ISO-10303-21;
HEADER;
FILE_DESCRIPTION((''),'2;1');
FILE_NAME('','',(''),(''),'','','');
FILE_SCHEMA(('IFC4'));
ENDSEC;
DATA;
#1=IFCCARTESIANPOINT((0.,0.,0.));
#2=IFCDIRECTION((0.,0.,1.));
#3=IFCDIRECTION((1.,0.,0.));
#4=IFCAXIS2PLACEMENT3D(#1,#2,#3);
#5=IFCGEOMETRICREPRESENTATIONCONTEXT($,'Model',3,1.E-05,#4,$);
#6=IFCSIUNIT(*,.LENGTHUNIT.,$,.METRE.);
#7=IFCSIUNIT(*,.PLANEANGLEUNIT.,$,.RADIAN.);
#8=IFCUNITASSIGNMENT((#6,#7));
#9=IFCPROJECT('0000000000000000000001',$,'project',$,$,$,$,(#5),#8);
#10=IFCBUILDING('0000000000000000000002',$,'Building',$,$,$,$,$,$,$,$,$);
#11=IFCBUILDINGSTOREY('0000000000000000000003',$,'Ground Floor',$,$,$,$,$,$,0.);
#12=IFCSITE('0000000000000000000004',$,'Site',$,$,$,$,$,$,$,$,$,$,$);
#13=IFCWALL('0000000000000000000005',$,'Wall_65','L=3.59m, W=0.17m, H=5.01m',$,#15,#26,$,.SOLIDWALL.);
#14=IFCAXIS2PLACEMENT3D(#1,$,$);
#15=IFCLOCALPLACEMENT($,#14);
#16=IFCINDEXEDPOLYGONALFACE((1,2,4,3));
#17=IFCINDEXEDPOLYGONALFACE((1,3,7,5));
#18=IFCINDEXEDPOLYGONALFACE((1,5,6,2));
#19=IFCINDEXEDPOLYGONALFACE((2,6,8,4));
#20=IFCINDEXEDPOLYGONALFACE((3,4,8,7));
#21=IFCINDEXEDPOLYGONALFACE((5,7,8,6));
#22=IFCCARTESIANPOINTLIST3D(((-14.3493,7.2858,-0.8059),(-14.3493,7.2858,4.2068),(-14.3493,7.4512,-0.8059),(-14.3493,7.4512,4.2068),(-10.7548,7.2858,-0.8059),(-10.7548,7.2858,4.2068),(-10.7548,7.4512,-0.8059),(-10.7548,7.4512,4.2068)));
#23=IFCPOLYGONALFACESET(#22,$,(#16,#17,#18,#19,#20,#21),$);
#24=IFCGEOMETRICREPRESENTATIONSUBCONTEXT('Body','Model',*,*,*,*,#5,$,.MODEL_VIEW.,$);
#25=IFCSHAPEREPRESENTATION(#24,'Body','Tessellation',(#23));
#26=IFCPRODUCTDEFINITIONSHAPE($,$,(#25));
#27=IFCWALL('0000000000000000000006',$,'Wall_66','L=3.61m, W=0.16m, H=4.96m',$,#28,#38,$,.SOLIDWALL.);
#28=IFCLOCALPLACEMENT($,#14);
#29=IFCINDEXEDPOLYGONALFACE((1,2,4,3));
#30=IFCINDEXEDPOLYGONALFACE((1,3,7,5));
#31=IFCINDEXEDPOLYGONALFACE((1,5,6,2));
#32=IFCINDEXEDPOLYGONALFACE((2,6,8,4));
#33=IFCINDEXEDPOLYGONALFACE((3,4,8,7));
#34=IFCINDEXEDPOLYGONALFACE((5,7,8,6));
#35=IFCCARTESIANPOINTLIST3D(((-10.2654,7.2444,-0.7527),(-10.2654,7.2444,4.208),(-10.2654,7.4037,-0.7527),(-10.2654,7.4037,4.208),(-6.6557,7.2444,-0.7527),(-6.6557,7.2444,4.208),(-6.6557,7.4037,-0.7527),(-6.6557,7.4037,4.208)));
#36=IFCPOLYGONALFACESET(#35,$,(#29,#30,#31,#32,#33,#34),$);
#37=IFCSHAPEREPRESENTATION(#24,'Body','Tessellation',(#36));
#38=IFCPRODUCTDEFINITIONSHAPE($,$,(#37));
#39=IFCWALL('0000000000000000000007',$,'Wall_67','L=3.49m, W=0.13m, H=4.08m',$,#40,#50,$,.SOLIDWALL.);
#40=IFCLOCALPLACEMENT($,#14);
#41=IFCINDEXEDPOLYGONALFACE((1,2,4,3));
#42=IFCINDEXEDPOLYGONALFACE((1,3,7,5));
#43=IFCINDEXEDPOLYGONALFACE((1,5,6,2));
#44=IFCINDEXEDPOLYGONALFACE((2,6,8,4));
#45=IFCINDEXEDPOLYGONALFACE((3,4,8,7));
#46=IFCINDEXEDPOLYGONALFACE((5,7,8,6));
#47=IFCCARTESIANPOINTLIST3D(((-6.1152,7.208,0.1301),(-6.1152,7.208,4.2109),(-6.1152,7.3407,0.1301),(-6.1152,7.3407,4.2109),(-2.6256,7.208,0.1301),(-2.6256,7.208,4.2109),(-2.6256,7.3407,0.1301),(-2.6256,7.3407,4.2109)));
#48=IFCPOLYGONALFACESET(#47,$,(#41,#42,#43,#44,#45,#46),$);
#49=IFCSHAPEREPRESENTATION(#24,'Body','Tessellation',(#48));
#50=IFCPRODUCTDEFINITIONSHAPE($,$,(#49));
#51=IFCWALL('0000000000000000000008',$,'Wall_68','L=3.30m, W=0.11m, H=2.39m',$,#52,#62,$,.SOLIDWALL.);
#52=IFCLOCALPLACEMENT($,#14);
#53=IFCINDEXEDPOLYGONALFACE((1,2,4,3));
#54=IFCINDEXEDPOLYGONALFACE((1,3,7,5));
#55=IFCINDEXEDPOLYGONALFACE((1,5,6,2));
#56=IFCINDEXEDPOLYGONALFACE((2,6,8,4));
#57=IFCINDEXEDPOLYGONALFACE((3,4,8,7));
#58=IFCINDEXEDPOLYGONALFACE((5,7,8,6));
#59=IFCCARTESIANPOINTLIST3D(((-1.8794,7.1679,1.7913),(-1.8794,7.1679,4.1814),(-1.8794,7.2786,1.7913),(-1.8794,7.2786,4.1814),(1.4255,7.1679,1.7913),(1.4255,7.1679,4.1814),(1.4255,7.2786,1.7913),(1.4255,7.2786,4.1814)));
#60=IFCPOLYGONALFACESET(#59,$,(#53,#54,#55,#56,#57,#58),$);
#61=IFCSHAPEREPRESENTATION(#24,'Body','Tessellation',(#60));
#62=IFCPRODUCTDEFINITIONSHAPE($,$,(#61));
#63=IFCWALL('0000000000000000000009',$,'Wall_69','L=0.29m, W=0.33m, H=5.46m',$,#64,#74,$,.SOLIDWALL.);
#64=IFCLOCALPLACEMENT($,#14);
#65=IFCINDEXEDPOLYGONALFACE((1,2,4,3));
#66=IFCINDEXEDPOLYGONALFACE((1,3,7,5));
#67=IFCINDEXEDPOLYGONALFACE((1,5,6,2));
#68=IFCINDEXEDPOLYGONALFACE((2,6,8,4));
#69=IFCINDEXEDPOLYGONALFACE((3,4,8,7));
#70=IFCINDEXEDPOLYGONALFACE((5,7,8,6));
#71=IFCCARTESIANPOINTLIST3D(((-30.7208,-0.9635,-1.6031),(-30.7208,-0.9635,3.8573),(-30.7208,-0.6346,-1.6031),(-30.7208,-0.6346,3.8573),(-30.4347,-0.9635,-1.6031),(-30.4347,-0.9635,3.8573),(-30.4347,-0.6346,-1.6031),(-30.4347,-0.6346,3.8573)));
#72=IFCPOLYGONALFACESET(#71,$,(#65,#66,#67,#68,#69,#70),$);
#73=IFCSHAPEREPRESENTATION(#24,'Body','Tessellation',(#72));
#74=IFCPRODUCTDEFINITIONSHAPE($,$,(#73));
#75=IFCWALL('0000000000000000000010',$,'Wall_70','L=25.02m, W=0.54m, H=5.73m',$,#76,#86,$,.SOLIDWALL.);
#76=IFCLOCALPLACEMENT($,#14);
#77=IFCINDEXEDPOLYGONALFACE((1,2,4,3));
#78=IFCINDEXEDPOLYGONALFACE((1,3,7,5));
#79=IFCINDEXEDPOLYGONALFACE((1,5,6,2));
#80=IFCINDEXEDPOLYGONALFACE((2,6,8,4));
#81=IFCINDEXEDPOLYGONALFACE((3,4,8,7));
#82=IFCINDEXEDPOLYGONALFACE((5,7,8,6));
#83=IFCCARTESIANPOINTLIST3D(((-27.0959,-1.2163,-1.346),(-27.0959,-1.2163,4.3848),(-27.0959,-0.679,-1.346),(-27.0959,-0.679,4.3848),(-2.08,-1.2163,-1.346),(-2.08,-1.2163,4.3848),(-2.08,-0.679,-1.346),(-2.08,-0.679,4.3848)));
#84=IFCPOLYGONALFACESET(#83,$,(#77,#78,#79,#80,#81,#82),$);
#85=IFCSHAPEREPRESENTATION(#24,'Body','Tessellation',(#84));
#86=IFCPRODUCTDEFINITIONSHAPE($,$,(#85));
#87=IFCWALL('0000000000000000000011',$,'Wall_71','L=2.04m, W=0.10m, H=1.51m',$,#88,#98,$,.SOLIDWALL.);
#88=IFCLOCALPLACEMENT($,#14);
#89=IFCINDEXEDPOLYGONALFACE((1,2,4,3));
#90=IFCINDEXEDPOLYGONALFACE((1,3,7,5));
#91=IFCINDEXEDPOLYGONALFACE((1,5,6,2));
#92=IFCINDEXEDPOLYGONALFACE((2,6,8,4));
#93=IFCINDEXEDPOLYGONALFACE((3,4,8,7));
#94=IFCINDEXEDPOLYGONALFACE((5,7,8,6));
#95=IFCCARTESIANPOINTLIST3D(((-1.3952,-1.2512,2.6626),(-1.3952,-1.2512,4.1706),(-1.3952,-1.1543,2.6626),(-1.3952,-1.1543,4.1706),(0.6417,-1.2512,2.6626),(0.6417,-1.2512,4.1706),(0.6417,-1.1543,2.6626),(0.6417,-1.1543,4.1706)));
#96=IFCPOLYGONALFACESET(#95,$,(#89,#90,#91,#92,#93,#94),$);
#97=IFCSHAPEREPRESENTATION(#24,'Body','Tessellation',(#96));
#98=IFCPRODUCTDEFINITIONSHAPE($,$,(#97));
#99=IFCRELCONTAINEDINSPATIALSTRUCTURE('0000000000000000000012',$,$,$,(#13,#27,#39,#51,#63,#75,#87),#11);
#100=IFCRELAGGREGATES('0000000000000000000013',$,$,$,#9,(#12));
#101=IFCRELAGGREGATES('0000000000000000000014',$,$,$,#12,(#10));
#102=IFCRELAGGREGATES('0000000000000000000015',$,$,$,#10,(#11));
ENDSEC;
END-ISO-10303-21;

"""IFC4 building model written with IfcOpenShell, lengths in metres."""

from ifc_helpers import new_model, si_unit, frame, origin_with_axes, origin_2d, context, subcontext, project, spatial, rectangle, extrude, element, save


model = new_model("IFC4")

# Units and contexts
model_context = context("Model", 3, precision=1e-05, world=origin_with_axes())
body_context = subcontext(model_context, "Body", "Model", "MODEL_VIEW")
ifc_project = project(units=[si_unit("LENGTHUNIT", "METRE"), si_unit("PLANEANGLEUNIT", "RADIAN")], contexts=[model_context])

# Site, building, storey
site = spatial("IfcSite", under=ifc_project, Name="Site")
building = spatial("IfcBuilding", under=site, Name="Building")
storey = spatial("IfcBuildingStorey", under=building, Name="Ground Floor", Elevation=0.0)

# Walls
element("IfcWall", 1, inside=storey, Name="Wall_65", Description="L=3.59m, W=0.17m, H=5.01m", PredefinedType="SOLIDWALL", context=body_context, shape_type="SweptSolid", body=[
    extrude(rectangle(XDim=3.5945, YDim=0.1655, at=origin_2d()), frame((-12.552, 7.3685, -0.8059), z_axis=(0.0, 0.0, 1.0), x_axis=(1.0, 0.0, 0.0)), (0.0, 0.0, 1.0), 5.0127),
])
element("IfcWall", 2, inside=storey, Name="Wall_66", Description="L=3.61m, W=0.16m, H=4.96m", PredefinedType="SOLIDWALL", context=body_context, shape_type="SweptSolid", body=[
    extrude(rectangle(XDim=3.6097, YDim=0.1593, at=origin_2d()), frame((-8.4605, 7.324, -0.7527), z_axis=(0.0, 0.0, 1.0), x_axis=(1.0, 0.0, 0.0)), (0.0, 0.0, 1.0), 4.9606),
])
element("IfcWall", 3, inside=storey, Name="Wall_67", Description="L=3.49m, W=0.13m, H=4.08m", PredefinedType="SOLIDWALL", context=body_context, shape_type="SweptSolid", body=[
    extrude(rectangle(XDim=3.4897, YDim=0.1327, at=origin_2d()), frame((-4.3704, 7.2743, 0.1301), z_axis=(0.0, 0.0, 1.0), x_axis=(1.0, 0.0, 0.0)), (0.0, 0.0, 1.0), 4.0809),
])
element("IfcWall", 4, inside=storey, Name="Wall_68", Description="L=3.30m, W=0.11m, H=2.39m", PredefinedType="SOLIDWALL", context=body_context, shape_type="SweptSolid", body=[
    extrude(rectangle(XDim=3.305, YDim=0.1107, at=origin_2d()), frame((-0.227, 7.2232, 1.7913), z_axis=(0.0, 0.0, 1.0), x_axis=(1.0, 0.0, 0.0)), (0.0, 0.0, 1.0), 2.3901),
])
element("IfcWall", 5, inside=storey, Name="Wall_69", Description="L=0.29m, W=0.33m, H=5.46m", PredefinedType="SOLIDWALL", context=body_context, shape_type="SweptSolid", body=[
    extrude(rectangle(XDim=0.2861, YDim=0.3289, at=origin_2d()), frame((-30.5778, -0.799, -1.6031), z_axis=(0.0, 0.0, 1.0), x_axis=(1.0, 0.0, 0.0)), (0.0, 0.0, 1.0), 5.4605),
])
element("IfcWall", 6, inside=storey, Name="Wall_70", Description="L=25.02m, W=0.54m, H=5.73m", PredefinedType="SOLIDWALL", context=body_context, shape_type="SweptSolid", body=[
    extrude(rectangle(XDim=25.0159, YDim=0.5374, at=origin_2d()), frame((-14.5879, -0.9476, -1.346), z_axis=(0.0, 0.0, 1.0), x_axis=(1.0, 0.0, 0.0)), (0.0, 0.0, 1.0), 5.7308),
])
element("IfcWall", 7, inside=storey, Name="Wall_71", Description="L=2.04m, W=0.10m, H=1.51m", PredefinedType="SOLIDWALL", context=body_context, shape_type="SweptSolid", body=[
    extrude(rectangle(XDim=2.037, YDim=0.097, at=origin_2d()), frame((-0.3768, -1.2027, 2.6626), z_axis=(0.0, 0.0, 1.0), x_axis=(1.0, 0.0, 0.0)), (0.0, 0.0, 1.0), 1.5081),
])

save(model, "model.ifc")
